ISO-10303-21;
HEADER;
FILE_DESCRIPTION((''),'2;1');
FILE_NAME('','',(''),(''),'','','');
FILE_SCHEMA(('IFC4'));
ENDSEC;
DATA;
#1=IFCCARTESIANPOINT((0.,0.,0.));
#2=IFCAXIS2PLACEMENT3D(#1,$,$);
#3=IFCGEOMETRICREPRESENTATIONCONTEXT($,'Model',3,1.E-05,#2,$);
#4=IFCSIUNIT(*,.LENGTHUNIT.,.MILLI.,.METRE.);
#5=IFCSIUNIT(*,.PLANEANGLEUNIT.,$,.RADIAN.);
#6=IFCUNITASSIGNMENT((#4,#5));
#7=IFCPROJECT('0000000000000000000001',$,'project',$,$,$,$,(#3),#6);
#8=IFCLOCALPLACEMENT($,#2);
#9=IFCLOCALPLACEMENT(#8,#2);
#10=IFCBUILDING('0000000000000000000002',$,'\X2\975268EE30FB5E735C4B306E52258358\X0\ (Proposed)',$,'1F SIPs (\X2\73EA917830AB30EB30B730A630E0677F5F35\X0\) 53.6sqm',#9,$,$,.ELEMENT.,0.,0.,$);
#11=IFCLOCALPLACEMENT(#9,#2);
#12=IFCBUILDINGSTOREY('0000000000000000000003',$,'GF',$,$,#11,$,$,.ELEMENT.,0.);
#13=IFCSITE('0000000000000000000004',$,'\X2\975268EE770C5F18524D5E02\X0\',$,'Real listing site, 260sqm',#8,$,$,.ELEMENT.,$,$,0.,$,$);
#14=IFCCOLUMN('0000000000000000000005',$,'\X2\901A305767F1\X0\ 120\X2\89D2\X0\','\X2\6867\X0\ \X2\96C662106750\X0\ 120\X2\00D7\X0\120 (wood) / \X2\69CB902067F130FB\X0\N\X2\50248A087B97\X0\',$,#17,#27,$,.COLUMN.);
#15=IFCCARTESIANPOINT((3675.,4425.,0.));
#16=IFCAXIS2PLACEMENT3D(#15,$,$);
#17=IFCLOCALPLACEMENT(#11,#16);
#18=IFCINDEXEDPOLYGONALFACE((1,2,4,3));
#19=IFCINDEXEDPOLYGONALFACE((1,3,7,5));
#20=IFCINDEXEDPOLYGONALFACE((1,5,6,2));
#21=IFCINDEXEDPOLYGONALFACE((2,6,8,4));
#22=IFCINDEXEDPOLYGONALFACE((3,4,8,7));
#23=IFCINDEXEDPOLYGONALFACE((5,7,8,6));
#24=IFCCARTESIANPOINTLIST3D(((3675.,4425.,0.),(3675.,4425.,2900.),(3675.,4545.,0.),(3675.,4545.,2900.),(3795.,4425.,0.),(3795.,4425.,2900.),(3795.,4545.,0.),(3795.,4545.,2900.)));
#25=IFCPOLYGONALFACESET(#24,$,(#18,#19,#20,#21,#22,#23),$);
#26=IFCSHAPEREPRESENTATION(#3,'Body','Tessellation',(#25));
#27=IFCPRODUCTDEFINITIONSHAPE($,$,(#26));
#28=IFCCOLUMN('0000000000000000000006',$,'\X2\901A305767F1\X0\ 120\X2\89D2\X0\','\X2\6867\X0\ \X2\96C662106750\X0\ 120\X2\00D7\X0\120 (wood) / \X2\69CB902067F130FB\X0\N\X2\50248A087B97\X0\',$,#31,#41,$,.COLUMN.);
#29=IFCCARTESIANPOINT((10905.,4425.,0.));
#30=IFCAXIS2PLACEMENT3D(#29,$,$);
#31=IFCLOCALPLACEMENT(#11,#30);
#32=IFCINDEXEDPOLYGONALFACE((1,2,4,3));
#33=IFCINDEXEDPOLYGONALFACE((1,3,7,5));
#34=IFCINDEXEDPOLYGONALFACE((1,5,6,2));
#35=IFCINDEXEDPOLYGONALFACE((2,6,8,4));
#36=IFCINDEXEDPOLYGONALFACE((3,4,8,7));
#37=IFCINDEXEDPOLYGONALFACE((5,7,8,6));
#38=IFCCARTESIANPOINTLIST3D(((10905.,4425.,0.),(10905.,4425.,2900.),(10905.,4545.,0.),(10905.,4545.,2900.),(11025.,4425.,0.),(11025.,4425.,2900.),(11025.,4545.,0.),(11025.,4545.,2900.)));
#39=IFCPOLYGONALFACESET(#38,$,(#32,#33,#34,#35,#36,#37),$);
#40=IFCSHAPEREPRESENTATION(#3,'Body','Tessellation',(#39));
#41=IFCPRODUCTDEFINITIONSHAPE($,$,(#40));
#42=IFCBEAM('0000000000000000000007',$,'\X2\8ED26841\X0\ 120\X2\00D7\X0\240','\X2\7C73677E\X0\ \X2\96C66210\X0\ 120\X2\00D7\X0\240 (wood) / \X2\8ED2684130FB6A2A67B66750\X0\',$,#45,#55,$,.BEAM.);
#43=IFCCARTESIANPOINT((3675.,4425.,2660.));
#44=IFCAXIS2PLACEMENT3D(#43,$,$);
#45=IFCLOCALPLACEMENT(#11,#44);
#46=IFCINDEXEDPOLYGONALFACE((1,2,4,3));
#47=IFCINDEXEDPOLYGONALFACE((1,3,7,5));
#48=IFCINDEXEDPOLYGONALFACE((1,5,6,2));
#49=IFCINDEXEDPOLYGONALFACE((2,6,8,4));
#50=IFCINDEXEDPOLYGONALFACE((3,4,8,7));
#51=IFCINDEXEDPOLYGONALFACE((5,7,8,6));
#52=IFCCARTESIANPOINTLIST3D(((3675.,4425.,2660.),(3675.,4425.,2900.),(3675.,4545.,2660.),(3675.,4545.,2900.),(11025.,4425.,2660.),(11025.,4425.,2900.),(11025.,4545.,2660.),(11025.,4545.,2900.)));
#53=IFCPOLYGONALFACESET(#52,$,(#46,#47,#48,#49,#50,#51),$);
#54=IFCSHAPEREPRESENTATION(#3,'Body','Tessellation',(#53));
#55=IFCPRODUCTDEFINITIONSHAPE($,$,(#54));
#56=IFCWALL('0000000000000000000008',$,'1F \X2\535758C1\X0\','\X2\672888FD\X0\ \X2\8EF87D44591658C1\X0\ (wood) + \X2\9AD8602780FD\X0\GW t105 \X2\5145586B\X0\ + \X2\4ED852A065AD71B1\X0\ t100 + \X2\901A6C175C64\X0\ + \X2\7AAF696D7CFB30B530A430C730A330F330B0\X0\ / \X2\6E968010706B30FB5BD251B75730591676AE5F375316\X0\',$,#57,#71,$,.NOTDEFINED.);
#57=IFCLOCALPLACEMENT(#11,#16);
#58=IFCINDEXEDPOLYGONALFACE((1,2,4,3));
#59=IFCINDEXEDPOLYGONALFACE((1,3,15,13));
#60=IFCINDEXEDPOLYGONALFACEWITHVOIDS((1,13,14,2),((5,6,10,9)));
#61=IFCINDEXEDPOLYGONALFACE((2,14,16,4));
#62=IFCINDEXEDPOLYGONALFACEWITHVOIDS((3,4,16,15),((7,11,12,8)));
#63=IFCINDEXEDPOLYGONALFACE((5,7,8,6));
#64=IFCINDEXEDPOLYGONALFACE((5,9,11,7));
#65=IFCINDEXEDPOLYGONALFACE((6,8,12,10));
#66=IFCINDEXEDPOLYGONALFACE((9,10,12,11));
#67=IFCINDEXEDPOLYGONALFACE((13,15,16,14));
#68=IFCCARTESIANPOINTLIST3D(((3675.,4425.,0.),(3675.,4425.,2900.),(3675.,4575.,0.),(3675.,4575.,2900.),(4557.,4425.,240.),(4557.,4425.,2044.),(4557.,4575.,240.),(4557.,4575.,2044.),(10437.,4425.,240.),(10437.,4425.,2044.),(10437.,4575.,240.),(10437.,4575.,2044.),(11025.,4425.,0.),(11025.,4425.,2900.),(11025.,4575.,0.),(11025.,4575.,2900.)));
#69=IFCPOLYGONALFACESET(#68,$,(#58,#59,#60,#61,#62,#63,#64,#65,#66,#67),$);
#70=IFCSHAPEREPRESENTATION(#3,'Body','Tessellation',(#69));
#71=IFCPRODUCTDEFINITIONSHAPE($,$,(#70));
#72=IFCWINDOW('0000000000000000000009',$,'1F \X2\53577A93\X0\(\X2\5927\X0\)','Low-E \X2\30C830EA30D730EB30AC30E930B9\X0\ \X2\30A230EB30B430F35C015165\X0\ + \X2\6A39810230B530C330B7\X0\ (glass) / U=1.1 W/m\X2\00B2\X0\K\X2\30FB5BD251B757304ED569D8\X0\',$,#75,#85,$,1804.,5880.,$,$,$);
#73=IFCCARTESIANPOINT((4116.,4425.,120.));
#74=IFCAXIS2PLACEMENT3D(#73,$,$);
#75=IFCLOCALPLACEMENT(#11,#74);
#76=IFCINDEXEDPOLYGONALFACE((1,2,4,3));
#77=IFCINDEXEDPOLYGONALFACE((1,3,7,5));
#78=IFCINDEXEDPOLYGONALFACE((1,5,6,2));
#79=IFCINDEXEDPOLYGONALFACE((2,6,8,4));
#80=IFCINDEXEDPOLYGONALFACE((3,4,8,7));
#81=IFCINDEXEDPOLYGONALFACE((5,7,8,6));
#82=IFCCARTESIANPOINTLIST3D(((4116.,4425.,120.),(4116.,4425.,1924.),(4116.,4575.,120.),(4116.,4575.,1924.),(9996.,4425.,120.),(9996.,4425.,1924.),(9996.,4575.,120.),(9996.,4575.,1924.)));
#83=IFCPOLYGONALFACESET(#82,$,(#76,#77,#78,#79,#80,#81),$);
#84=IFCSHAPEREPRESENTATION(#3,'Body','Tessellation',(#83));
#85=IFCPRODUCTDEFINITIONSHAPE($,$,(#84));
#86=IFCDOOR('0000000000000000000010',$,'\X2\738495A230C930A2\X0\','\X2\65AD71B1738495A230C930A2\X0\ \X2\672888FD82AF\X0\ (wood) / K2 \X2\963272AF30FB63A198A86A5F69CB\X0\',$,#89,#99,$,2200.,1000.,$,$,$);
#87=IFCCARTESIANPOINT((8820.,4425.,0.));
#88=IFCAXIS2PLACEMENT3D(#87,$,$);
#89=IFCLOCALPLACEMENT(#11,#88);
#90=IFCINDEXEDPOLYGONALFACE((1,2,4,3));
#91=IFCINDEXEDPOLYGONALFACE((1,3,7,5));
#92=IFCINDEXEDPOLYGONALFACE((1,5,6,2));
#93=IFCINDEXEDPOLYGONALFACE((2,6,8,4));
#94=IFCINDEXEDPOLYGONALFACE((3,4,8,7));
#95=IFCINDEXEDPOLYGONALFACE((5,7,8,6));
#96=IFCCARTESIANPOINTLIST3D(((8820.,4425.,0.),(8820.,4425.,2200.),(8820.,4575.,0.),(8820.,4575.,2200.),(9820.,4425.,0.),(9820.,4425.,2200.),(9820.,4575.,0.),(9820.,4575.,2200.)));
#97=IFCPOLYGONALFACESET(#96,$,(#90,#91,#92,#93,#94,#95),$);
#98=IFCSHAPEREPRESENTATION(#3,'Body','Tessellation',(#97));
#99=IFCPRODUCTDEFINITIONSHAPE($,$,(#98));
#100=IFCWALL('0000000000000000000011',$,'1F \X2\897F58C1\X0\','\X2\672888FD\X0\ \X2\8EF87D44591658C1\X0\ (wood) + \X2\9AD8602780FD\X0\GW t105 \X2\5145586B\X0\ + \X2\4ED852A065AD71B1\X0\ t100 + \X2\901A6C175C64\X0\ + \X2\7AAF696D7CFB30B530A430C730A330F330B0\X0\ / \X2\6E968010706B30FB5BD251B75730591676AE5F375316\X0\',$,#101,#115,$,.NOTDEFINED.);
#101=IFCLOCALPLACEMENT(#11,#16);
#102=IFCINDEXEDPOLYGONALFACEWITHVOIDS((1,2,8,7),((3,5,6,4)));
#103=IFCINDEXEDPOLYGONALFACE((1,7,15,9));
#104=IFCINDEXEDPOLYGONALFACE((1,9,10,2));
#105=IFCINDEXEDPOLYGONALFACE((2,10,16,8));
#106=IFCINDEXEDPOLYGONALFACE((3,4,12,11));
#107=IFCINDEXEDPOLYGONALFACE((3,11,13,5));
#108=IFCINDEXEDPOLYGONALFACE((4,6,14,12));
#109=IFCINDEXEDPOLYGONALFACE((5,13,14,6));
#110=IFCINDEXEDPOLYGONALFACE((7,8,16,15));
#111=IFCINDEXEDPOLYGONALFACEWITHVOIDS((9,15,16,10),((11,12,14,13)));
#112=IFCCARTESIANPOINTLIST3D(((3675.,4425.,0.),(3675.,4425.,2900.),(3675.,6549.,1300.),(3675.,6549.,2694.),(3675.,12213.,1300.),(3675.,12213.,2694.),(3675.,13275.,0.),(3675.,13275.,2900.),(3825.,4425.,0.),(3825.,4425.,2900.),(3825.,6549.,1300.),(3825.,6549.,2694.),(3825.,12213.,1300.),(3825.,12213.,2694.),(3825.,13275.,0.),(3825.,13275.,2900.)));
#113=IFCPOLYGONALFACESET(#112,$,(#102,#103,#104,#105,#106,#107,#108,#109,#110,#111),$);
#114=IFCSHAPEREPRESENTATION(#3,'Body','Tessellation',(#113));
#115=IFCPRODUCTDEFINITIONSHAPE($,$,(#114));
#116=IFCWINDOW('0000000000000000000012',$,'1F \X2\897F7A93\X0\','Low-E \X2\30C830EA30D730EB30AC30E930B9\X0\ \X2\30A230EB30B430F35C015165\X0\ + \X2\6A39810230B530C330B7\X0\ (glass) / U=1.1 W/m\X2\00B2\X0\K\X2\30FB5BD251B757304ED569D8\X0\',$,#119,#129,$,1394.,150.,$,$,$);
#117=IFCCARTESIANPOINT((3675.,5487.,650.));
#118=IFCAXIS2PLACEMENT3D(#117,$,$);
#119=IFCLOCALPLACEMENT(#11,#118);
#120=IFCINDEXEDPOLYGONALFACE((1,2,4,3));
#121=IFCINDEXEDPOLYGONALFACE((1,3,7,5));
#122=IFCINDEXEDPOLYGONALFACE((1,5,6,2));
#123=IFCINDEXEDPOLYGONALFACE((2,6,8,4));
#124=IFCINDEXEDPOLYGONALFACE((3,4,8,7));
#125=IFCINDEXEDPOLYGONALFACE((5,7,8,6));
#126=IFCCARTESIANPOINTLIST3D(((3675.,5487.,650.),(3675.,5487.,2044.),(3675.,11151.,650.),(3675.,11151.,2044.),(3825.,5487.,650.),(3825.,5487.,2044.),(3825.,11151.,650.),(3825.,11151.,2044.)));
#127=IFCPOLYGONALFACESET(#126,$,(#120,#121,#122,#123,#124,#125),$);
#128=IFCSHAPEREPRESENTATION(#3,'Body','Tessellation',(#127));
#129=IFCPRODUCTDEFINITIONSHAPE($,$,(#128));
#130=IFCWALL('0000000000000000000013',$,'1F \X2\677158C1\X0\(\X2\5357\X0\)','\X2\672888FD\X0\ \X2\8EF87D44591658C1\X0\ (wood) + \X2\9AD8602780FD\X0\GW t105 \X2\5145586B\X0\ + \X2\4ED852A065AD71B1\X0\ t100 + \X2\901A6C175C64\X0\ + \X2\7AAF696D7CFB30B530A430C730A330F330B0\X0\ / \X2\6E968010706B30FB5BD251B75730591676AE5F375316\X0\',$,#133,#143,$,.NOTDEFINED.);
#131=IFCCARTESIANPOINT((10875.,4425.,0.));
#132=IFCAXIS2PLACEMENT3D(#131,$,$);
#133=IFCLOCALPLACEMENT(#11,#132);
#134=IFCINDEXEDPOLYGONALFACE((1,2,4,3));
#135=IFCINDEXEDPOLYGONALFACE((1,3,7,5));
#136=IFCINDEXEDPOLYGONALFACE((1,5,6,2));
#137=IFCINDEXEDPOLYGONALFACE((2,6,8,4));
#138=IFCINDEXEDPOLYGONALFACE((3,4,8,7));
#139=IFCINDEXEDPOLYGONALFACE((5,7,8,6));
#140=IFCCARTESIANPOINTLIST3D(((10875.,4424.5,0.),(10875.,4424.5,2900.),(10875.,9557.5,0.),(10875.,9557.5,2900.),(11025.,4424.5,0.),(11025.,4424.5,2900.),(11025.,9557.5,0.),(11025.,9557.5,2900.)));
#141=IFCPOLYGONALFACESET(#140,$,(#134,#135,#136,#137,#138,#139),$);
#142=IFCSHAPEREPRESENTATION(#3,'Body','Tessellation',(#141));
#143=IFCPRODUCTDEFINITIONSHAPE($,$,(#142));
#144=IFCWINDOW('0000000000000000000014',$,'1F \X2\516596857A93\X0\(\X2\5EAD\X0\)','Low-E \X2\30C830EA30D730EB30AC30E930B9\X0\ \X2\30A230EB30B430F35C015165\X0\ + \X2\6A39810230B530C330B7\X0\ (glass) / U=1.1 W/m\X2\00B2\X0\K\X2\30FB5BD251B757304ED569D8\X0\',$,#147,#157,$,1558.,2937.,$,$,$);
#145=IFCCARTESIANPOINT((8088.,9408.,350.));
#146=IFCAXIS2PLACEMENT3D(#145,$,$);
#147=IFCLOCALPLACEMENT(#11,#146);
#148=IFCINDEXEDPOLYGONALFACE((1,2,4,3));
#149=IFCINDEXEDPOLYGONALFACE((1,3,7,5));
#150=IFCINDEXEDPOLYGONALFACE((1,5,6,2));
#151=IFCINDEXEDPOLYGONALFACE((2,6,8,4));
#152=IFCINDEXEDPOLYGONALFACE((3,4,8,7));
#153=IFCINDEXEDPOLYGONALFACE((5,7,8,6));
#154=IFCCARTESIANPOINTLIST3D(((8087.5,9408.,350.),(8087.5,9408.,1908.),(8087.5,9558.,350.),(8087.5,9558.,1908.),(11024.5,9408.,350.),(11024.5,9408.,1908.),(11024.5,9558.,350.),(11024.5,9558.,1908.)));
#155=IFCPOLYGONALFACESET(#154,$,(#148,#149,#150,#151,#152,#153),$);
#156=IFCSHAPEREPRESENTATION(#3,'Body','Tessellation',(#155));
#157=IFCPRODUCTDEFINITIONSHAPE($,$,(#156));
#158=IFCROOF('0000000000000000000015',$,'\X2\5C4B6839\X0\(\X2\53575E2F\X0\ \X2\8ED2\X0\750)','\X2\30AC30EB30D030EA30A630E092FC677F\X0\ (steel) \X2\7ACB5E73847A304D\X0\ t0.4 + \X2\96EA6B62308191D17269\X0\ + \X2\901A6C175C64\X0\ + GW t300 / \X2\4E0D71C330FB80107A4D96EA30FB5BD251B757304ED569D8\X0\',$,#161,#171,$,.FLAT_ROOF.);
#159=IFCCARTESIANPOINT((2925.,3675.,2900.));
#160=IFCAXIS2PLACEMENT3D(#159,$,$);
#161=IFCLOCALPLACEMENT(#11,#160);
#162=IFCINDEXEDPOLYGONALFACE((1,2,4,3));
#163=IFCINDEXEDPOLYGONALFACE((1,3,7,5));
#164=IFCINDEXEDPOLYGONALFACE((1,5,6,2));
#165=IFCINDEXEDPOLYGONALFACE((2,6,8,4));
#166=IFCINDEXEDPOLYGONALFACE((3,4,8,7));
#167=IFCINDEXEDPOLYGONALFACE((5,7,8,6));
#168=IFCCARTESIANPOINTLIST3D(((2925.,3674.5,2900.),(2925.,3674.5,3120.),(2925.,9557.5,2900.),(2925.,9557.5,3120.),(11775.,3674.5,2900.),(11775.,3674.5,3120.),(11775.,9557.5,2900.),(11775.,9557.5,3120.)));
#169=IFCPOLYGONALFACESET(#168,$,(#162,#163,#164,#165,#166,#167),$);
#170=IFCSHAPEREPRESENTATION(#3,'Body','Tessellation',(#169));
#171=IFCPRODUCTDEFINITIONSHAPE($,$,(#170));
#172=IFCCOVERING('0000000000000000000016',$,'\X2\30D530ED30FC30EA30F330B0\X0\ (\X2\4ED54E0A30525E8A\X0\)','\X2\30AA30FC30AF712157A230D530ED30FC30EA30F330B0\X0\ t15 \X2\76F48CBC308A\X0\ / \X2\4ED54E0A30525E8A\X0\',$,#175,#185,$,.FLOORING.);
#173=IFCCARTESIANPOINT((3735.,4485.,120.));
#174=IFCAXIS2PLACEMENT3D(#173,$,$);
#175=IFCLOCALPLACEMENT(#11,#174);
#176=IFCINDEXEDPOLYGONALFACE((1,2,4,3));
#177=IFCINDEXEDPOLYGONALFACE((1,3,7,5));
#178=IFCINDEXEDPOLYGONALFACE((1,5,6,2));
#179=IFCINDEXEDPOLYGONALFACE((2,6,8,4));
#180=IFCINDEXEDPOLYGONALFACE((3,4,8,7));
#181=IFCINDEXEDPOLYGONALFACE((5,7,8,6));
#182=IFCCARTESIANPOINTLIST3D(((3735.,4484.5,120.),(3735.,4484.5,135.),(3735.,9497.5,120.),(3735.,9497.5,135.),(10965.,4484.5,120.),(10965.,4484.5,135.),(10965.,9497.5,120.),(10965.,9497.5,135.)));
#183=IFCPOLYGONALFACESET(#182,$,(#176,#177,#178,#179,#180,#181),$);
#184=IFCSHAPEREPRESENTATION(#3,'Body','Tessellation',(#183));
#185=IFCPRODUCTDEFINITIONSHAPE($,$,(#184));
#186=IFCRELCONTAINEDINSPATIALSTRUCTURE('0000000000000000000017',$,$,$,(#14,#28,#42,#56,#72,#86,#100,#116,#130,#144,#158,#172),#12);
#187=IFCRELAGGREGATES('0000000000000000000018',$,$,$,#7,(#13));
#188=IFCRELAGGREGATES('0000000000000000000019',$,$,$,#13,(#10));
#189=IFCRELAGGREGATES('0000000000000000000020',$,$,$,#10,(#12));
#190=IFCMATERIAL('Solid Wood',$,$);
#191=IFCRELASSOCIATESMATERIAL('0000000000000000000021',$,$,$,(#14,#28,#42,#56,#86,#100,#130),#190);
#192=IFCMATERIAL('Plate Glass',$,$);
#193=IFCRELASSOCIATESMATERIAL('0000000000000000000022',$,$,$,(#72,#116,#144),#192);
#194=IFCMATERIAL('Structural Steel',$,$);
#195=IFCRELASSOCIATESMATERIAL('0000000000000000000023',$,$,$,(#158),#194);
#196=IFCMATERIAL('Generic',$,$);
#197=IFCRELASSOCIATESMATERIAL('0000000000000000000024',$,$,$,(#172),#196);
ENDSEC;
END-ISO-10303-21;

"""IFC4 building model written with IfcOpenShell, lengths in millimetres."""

from ifc_helpers import new_model, si_unit, frame, frame_2d, origin, place, context, project, spatial, rectangle, extrude, material, element, fill, save


model = new_model("IFC4")

# Units and contexts
model_context = context("Model", 3, precision=1e-05, world=origin())
ifc_project = project(units=[si_unit("LENGTHUNIT", "METRE", prefix="MILLI"), si_unit("PLANEANGLEUNIT", "RADIAN")], contexts=[model_context])

# Site, building, storey
site_placement = place(None, origin())
site = spatial("IfcSite", under=ifc_project, at=site_placement, Name="青森県弘前市", ObjectType="Real listing site, 260sqm", CompositionType="ELEMENT", RefElevation=0.0)
building_placement = place(site_placement, origin())
building = spatial("IfcBuilding", under=site, at=building_placement, Name="青森・平屋の別荘 (Proposed)", ObjectType="1F SIPs (珪酸カルシウム板張) 53.6sqm", CompositionType="ELEMENT", ElevationOfRefHeight=0.0, ElevationOfTerrain=0.0)
storey_placement = place(building_placement, origin())
storey = spatial("IfcBuildingStorey", under=building, at=storey_placement, Name="GF", CompositionType="ELEMENT", Elevation=0.0)

# Columns
ifc_material_1 = material(Name="Solid Wood")
column_1_placement = place(storey_placement, frame((3675.0, 4425.0, 0.0)))
element("IfcColumn", 1, at=column_1_placement, inside=storey, material=ifc_material_1, Name="通し柱 120角", Description="桧 集成材 120×120 (wood) / 構造柱・N値計算", PredefinedType="COLUMN", context=model_context, shape_type="SweptSolid", body=[
    extrude(rectangle(XDim=120.0, YDim=120.0, at=frame_2d((60.0, 60.0))), frame((3675.0, 4425.0, 0.0)), (0.0, 0.0, 1.0), 2900.0),
])
column_2_placement = place(storey_placement, frame((10905.0, 4425.0, 0.0)))
element("IfcColumn", 2, at=column_2_placement, inside=storey, material=ifc_material_1, Name="通し柱 120角", Description="桧 集成材 120×120 (wood) / 構造柱・N値計算", PredefinedType="COLUMN", context=model_context, shape_type="SweptSolid", body=[
    extrude(rectangle(XDim=120.0, YDim=120.0, at=frame_2d((60.0, 60.0))), frame((10905.0, 4425.0, 0.0)), (0.0, 0.0, 1.0), 2900.0),
])

# Beam
beam_1_placement = place(storey_placement, frame((3675.0, 4425.0, 2660.0)))
element("IfcBeam", 3, at=beam_1_placement, inside=storey, material=ifc_material_1, Name="軒桁 120×240", Description="米松 集成 120×240 (wood) / 軒桁・横架材", PredefinedType="BEAM", context=model_context, shape_type="SweptSolid", body=[
    extrude(rectangle(XDim=7350.0, YDim=120.0, at=frame_2d((3675.0, 60.0))), frame((3675.0, 4425.0, 2660.0)), (0.0, 0.0, 1.0), 240.0),
])

# Wall, openings, window, door
wall_1_placement = place(storey_placement, frame((3675.0, 4425.0, 0.0)))
wall_1 = element("IfcWall", 4, at=wall_1_placement, inside=storey, material=ifc_material_1, Name="1F 南壁", Description="木製 軸組外壁 (wood) + 高性能GW t105 充填 + 付加断熱 t100 + 通気層 + 窯業系サイディング / 準耐火・寒冷地外皮強化", PredefinedType="NOTDEFINED", context=model_context, shape_type="SweptSolid", body=[
    extrude(rectangle(XDim=7350.0, YDim=150.0, at=frame_2d((3675.0, 75.0))), frame((3675.0, 4425.0, 0.0)), (0.0, 0.0, 1.0), 2900.0),
])
opening_1_placement = place(storey_placement, frame((4116.0, 4425.0, 120.0)))
opening_1 = element("IfcOpeningElement", 5, at=opening_1_placement, cuts=wall_1, PredefinedType="NOTDEFINED", context=model_context, shape_type="SweptSolid", body=[
    extrude(rectangle(XDim=5880.0, YDim=150.0, at=frame_2d((2940.0, 75.0))), frame((4116.0, 4425.0, 120.0)), (0.0, 0.0, 1.0), 1804.0),
])
opening_2_placement = place(storey_placement, frame((8820.0, 4425.0, 0.0)))
opening_2 = element("IfcOpeningElement", 6, at=opening_2_placement, cuts=wall_1, PredefinedType="NOTDEFINED", context=model_context, shape_type="SweptSolid", body=[
    extrude(rectangle(XDim=1000.0, YDim=150.0, at=frame_2d((500.0, 75.0))), frame((8820.0, 4425.0, 0.0)), (0.0, 0.0, 1.0), 2200.0),
])
ifc_material_2 = material(Name="Plate Glass")
window_1_placement = place(storey_placement, frame((4116.0, 4425.0, 120.0)))
window_1 = element("IfcWindow", 7, at=window_1_placement, inside=storey, material=ifc_material_2, Name="1F 南窓(大)", Description="Low-E トリプルガラス アルゴン封入 + 樹脂サッシ (glass) / U=1.1 W/m²K・寒冷地仕様", OverallHeight=1804.0, OverallWidth=5880.0, context=model_context, shape_type="SweptSolid", body=[
    extrude(rectangle(XDim=5880.0, YDim=150.0, at=frame_2d((2940.0, 75.0))), frame((4116.0, 4425.0, 120.0)), (0.0, 0.0, 1.0), 1804.0),
])
fill(opening_1, window_1)
door_1_placement = place(storey_placement, frame((8820.0, 4425.0, 0.0)))
door_1 = element("IfcDoor", 8, at=door_1_placement, inside=storey, material=ifc_material_1, Name="玄関ドア", Description="断熱玄関ドア 木製芯 (wood) / K2 防犯・採風機構", OverallHeight=2200.0, OverallWidth=1000.0, context=model_context, shape_type="SweptSolid", body=[
    extrude(rectangle(XDim=1000.0, YDim=150.0, at=frame_2d((500.0, 75.0))), frame((8820.0, 4425.0, 0.0)), (0.0, 0.0, 1.0), 2200.0),
])
fill(opening_2, door_1)

# Walls, openings, windows
wall_2_placement = place(storey_placement, frame((3675.0, 4425.0, 0.0)))
wall_2 = element("IfcWall", 9, at=wall_2_placement, inside=storey, material=ifc_material_1, Name="1F 西壁", Description="木製 軸組外壁 (wood) + 高性能GW t105 充填 + 付加断熱 t100 + 通気層 + 窯業系サイディング / 準耐火・寒冷地外皮強化", PredefinedType="NOTDEFINED", context=model_context, shape_type="SweptSolid", body=[
    extrude(rectangle(XDim=150.0, YDim=8850.0, at=frame_2d((75.0, 4425.0))), frame((3675.0, 4425.0, 0.0)), (0.0, 0.0, 1.0), 2900.0),
])
opening_3_placement = place(storey_placement, frame((3675.0, 5487.0, 650.0)))
opening_3 = element("IfcOpeningElement", 10, at=opening_3_placement, cuts=wall_2, PredefinedType="NOTDEFINED", context=model_context, shape_type="SweptSolid", body=[
    extrude(rectangle(XDim=150.0, YDim=5664.0, at=frame_2d((75.0, 2832.0))), frame((3675.0, 5487.0, 650.0)), (0.0, 0.0, 1.0), 1394.0),
])
window_2_placement = place(storey_placement, frame((3675.0, 5487.0, 650.0)))
window_2 = element("IfcWindow", 11, at=window_2_placement, inside=storey, material=ifc_material_2, Name="1F 西窓", Description="Low-E トリプルガラス アルゴン封入 + 樹脂サッシ (glass) / U=1.1 W/m²K・寒冷地仕様", OverallHeight=1394.0, OverallWidth=150.0, context=model_context, shape_type="SweptSolid", body=[
    extrude(rectangle(XDim=150.0, YDim=5664.0, at=frame_2d((75.0, 2832.0))), frame((3675.0, 5487.0, 650.0)), (0.0, 0.0, 1.0), 1394.0),
])
fill(opening_3, window_2)
wall_3_placement = place(storey_placement, frame((10875.0, 4425.0, 0.0)))
wall_3 = element("IfcWall", 12, at=wall_3_placement, inside=storey, material=ifc_material_1, Name="1F 東壁(南)", Description="木製 軸組外壁 (wood) + 高性能GW t105 充填 + 付加断熱 t100 + 通気層 + 窯業系サイディング / 準耐火・寒冷地外皮強化", PredefinedType="NOTDEFINED", context=model_context, shape_type="SweptSolid", body=[
    extrude(rectangle(XDim=150.0, YDim=5133.0, at=frame_2d((75.0, 2566.0))), frame((10875.0, 4425.0, 0.0)), (0.0, 0.0, 1.0), 2900.0),
])
opening_4_placement = place(storey_placement, frame((8088.0, 9408.0, 350.0)))
opening_4 = element("IfcOpeningElement", 13, at=opening_4_placement, cuts=wall_3, PredefinedType="NOTDEFINED", context=model_context, shape_type="SweptSolid", body=[
    extrude(rectangle(XDim=2937.0, YDim=150.0, at=frame_2d((1468.0, 75.0))), frame((8088.0, 9408.0, 350.0)), (0.0, 0.0, 1.0), 1558.0),
])
window_3_placement = place(storey_placement, frame((8088.0, 9408.0, 350.0)))
window_3 = element("IfcWindow", 14, at=window_3_placement, inside=storey, material=ifc_material_2, Name="1F 入隅窓(庭)", Description="Low-E トリプルガラス アルゴン封入 + 樹脂サッシ (glass) / U=1.1 W/m²K・寒冷地仕様", OverallHeight=1558.0, OverallWidth=2937.0, context=model_context, shape_type="SweptSolid", body=[
    extrude(rectangle(XDim=2937.0, YDim=150.0, at=frame_2d((1468.0, 75.0))), frame((8088.0, 9408.0, 350.0)), (0.0, 0.0, 1.0), 1558.0),
])
fill(opening_4, window_3)

# Roof
ifc_material_3 = material(Name="Structural Steel")
roof_placement = place(storey_placement, frame((2925.0, 3675.0, 2900.0)))
element("IfcRoof", 15, at=roof_placement, inside=storey, material=ifc_material_3, Name="屋根(南帯 軒750)", Description="ガルバリウム鋼板 (steel) 立平葺き t0.4 + 雪止め金物 + 通気層 + GW t300 / 不燃・耐積雪・寒冷地仕様", PredefinedType="FLAT_ROOF", context=model_context, shape_type="SweptSolid", body=[
    extrude(rectangle(XDim=8850.0, YDim=5883.0, at=frame_2d((4425.0, 2941.0))), frame((2925.0, 3675.0, 2900.0)), (0.0, 0.0, 1.0), 220.0),
])

# Covering
ifc_material_4 = material(Name="Generic")
covering_1_placement = place(storey_placement, frame((3735.0, 4485.0, 120.0)))
element("IfcCovering", 16, at=covering_1_placement, inside=storey, material=ifc_material_4, Name="フローリング (仕上げ床)", Description="オーク無垢フローリング t15 直貼り / 仕上げ床", PredefinedType="FLOORING", context=model_context, shape_type="SweptSolid", body=[
    extrude(rectangle(XDim=7230.0, YDim=5013.0, at=frame_2d((3615.0, 2506.0))), frame((3735.0, 4485.0, 120.0)), (0.0, 0.0, 1.0), 15.0),
])

save(model, "model.ifc")
